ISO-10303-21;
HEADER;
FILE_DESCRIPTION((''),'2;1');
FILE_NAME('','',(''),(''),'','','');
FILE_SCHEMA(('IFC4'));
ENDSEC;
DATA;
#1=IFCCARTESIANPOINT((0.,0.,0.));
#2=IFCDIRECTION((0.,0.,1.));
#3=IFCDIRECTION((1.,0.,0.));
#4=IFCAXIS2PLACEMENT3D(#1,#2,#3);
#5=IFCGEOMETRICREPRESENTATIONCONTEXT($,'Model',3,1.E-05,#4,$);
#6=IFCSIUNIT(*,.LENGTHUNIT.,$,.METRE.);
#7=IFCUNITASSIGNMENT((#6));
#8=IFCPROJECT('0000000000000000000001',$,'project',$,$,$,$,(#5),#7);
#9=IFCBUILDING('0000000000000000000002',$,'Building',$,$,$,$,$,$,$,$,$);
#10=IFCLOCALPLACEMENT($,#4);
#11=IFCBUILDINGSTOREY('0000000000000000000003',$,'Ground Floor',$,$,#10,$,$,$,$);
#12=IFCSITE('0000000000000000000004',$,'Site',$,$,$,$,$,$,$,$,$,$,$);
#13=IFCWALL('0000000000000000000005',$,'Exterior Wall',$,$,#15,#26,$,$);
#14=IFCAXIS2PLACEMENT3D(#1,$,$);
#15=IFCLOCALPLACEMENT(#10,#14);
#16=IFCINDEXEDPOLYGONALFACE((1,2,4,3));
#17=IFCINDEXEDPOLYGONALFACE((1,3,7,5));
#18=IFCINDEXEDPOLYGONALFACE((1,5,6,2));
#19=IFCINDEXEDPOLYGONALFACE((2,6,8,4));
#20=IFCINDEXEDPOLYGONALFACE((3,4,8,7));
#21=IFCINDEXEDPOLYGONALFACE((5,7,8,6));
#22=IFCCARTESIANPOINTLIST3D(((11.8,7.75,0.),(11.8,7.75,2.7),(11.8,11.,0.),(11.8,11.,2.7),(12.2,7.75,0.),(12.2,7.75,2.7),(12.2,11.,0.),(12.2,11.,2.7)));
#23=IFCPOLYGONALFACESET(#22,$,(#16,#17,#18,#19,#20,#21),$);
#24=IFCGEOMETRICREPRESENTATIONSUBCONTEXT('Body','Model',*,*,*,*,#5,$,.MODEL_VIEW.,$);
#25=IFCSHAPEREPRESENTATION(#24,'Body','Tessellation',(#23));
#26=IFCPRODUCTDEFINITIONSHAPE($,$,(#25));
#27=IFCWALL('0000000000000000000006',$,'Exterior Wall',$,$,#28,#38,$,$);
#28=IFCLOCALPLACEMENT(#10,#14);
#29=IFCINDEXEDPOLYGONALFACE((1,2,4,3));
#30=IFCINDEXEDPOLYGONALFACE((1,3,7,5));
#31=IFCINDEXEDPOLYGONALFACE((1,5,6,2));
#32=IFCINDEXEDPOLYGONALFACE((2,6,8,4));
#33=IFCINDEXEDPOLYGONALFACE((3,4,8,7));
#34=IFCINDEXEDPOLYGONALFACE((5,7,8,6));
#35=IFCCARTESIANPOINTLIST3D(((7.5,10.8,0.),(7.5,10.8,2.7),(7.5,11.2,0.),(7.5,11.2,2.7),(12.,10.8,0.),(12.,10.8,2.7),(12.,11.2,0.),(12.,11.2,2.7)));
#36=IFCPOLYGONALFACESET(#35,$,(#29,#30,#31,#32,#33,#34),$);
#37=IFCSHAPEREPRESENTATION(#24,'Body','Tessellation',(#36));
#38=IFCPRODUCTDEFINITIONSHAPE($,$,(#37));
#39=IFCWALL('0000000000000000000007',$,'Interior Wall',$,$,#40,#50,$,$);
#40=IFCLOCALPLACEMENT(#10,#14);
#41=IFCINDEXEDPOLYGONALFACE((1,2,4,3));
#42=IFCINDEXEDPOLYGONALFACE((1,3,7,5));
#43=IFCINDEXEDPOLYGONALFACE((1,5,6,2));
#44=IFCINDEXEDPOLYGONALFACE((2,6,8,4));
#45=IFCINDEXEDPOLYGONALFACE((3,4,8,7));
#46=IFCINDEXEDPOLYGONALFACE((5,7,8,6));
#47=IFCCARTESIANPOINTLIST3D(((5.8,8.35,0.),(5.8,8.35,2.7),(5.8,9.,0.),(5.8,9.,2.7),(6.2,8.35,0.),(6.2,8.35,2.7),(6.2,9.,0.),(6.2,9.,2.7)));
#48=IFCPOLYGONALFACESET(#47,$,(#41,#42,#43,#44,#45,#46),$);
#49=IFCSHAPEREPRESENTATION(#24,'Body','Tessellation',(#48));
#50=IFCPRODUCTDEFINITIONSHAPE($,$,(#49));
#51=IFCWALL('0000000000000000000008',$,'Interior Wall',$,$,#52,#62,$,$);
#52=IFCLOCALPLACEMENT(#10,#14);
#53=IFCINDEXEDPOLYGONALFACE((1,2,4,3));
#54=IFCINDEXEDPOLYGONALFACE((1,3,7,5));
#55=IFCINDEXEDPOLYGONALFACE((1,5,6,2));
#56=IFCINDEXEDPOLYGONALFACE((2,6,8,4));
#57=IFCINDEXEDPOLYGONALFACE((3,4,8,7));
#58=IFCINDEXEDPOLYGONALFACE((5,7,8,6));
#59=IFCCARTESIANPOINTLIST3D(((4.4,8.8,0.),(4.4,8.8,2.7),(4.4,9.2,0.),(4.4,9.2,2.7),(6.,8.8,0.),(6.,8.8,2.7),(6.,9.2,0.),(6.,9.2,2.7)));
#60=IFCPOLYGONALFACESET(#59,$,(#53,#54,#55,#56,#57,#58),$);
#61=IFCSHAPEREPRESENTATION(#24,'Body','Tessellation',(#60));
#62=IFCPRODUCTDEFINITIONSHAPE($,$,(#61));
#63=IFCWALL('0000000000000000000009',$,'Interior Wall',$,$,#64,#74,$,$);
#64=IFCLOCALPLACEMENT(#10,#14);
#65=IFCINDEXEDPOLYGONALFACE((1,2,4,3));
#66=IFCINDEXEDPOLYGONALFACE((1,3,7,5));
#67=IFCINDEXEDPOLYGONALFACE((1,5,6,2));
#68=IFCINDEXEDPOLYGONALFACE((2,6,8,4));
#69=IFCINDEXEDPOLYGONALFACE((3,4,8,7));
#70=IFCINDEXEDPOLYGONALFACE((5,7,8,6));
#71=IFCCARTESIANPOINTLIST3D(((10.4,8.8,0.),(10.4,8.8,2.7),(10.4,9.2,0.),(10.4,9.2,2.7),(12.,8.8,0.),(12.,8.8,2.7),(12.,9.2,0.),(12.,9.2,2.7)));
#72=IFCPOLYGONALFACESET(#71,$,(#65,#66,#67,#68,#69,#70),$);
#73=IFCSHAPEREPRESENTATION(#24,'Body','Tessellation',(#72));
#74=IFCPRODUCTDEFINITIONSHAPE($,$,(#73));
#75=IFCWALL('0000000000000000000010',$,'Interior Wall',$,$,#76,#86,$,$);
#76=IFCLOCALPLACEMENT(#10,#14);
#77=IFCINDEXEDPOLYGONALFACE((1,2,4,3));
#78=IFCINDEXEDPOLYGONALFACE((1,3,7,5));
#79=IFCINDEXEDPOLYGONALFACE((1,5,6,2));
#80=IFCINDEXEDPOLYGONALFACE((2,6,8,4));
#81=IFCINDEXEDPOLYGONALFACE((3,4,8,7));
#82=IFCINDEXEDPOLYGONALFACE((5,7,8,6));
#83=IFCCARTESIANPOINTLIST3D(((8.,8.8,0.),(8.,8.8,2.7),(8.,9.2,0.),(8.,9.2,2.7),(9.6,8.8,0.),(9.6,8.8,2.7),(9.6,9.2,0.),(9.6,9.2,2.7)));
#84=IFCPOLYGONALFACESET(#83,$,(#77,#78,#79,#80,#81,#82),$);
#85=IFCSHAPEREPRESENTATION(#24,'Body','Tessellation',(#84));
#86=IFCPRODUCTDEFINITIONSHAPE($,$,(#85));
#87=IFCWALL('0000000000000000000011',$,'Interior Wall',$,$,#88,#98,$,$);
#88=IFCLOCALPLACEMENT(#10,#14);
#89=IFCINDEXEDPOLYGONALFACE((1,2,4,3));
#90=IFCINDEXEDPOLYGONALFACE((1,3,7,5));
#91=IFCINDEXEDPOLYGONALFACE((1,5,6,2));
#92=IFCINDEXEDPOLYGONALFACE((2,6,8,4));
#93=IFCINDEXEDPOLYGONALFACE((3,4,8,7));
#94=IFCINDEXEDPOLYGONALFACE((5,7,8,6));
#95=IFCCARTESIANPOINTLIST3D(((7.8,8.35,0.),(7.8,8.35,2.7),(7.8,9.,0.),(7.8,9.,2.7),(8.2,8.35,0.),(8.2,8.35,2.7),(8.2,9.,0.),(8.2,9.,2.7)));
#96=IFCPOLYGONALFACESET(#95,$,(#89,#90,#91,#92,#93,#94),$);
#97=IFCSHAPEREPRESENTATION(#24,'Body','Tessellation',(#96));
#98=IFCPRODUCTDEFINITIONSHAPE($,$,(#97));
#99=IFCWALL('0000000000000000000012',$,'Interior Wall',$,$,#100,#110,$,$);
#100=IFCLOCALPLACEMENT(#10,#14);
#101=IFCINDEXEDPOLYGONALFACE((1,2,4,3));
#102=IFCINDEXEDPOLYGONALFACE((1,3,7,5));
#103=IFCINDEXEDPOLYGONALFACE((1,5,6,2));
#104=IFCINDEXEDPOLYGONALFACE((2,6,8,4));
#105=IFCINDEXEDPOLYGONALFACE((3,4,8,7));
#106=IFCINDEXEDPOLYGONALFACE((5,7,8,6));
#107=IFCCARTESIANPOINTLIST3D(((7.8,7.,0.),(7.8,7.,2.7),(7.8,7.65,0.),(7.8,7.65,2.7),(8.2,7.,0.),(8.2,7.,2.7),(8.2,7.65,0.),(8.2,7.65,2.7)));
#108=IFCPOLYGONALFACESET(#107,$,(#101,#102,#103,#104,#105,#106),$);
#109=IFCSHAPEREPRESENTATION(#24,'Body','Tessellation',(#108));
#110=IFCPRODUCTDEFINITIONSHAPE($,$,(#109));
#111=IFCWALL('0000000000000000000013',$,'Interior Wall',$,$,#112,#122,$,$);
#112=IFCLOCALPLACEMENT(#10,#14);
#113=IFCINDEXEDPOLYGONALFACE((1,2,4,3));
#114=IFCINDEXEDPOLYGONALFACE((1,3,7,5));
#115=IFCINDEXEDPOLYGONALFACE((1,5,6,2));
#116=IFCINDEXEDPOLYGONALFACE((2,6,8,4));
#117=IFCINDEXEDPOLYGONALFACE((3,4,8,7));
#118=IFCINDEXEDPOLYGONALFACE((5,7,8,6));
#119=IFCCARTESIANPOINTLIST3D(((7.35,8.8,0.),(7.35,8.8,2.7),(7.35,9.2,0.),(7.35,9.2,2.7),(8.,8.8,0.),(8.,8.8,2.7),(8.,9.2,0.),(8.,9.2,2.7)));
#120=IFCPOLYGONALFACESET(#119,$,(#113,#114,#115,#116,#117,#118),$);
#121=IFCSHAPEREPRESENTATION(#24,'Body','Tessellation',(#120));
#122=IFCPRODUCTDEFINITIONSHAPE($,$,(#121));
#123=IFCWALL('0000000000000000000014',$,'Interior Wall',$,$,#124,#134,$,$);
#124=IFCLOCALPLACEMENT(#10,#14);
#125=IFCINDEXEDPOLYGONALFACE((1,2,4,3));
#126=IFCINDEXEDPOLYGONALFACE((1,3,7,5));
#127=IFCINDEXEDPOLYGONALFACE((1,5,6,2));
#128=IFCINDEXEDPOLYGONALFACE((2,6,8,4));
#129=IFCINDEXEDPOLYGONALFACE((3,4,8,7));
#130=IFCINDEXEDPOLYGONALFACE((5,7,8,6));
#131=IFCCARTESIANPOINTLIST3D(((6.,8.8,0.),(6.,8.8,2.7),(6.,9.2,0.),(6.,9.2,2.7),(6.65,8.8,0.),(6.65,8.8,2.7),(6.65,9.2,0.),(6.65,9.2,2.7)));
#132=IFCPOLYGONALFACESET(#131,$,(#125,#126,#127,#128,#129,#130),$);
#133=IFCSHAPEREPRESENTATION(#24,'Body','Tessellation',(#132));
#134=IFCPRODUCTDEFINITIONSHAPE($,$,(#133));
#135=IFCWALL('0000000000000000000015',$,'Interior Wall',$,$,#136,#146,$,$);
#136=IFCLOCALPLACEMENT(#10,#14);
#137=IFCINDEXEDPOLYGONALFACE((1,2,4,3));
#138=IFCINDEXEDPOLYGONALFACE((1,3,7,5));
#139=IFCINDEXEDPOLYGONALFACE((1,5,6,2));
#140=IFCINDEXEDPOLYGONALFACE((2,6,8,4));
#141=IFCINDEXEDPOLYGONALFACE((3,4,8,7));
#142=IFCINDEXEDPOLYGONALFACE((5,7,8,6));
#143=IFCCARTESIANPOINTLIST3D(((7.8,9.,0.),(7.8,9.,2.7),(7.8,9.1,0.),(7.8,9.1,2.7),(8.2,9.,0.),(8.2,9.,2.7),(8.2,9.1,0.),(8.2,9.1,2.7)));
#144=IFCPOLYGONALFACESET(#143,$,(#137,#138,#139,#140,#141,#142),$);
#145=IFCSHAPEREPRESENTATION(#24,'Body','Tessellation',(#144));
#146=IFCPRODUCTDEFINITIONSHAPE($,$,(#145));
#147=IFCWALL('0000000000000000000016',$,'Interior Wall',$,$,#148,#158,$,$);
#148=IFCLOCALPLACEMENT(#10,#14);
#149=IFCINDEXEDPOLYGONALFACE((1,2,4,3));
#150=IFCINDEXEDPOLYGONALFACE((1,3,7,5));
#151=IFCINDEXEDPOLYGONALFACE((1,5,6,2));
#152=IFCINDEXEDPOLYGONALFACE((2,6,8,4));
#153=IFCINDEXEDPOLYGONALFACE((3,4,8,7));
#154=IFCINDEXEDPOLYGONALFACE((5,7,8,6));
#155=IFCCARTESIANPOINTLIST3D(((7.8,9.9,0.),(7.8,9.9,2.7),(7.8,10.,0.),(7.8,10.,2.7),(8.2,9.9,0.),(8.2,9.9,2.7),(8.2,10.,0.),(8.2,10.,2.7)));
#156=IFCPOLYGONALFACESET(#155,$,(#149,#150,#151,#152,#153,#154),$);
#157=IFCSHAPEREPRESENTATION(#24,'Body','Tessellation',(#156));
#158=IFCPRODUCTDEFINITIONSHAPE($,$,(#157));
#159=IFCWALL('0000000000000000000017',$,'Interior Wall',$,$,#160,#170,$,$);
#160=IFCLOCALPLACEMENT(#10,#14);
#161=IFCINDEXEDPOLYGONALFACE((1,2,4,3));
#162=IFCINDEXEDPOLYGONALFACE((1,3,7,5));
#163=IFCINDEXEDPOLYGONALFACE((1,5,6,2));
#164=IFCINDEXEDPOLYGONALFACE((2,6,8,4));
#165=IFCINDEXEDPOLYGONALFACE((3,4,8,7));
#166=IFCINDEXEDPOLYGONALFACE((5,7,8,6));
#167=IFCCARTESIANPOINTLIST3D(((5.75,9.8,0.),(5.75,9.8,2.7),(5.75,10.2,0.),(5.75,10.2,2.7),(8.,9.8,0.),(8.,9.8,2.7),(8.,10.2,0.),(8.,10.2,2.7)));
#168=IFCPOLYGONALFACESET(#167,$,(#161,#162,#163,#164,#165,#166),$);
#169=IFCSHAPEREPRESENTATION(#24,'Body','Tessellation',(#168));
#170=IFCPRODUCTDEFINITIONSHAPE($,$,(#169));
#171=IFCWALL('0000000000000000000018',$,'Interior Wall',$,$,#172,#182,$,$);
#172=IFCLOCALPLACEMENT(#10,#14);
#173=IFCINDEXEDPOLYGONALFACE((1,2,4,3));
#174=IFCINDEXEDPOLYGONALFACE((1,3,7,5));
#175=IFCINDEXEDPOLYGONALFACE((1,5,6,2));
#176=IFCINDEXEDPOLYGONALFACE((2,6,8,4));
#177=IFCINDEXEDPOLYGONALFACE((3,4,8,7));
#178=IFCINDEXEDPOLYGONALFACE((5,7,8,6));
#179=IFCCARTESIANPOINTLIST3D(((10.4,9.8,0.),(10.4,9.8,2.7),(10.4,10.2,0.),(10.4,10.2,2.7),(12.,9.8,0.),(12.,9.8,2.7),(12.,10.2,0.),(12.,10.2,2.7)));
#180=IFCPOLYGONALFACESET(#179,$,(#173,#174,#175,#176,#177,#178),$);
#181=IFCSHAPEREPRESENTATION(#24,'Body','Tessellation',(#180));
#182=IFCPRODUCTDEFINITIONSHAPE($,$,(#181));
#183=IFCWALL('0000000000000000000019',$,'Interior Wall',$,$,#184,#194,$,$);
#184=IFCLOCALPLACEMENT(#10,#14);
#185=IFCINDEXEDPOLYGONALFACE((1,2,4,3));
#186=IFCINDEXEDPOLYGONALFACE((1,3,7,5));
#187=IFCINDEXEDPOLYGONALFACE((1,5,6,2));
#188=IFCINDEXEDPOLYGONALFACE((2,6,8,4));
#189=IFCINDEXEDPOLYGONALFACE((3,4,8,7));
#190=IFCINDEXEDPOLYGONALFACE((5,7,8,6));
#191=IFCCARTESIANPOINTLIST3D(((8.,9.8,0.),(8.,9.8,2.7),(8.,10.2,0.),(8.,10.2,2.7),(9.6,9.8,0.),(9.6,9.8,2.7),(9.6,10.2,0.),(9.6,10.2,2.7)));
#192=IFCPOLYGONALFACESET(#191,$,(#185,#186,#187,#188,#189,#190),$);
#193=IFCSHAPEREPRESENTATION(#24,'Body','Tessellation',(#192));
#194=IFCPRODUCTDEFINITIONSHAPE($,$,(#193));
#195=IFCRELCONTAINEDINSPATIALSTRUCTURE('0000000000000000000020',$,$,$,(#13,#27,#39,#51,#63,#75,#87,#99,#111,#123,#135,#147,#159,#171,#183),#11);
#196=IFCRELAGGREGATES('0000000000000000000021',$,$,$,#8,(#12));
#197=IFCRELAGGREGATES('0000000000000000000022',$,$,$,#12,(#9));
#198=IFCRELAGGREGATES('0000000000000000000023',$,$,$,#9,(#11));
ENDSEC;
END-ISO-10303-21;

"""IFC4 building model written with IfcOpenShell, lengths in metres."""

from ifc_helpers import new_model, si_unit, frame, origin_with_axes, place, context, subcontext, project, spatial, indexed_curve, outline, extrude, element, save


model = new_model("IFC4")

# Units and contexts
model_context = context("Model", 3, precision=1e-05, world=origin_with_axes())
body_context = subcontext(model_context, "Body", "Model", "MODEL_VIEW")
ifc_project = project(units=[si_unit("LENGTHUNIT", "METRE")], contexts=[model_context])

# Site, building, storey
site = spatial("IfcSite", under=ifc_project, Name="Site")
building = spatial("IfcBuilding", under=site, Name="Building")
storey_placement = place(None, origin_with_axes())
storey = spatial("IfcBuildingStorey", under=building, at=storey_placement, Name="Ground Floor")

# Walls
wall_1_placement = place(storey_placement, frame((12.0, 7.75, 0.0), z_axis=(0.0, 0.0, 1.0), x_axis=(0.0, 1.0, 0.0)))
element("IfcWall", 1, at=wall_1_placement, inside=storey, Name="Exterior Wall", context=body_context, shape_type="SweptSolid", body=[
    extrude(outline(indexed_curve([(0.0, 0.0), (0.0, 0.4), (3.25, 0.4), (3.25, 0.0), (0.0, 0.0)], self_intersect=False)), frame((0.0, -0.2, 0.0), z_axis=(0.0, 0.0, 1.0), x_axis=(1.0, 0.0, 0.0)), (0.0, 0.0, 1.0), 2.7),
])
wall_2_placement = place(storey_placement, frame((12.0, 11.0, 0.0), z_axis=(0.0, 0.0, 1.0), x_axis=(-1.0, 0.0, 0.0)))
element("IfcWall", 2, at=wall_2_placement, inside=storey, Name="Exterior Wall", context=body_context, shape_type="SweptSolid", body=[
    extrude(outline(indexed_curve([(0.0, 0.0), (0.0, 0.4), (4.5, 0.4), (4.5, 0.0), (0.0, 0.0)], self_intersect=False)), frame((0.0, -0.2, 0.0), z_axis=(0.0, 0.0, 1.0), x_axis=(1.0, 0.0, 0.0)), (0.0, 0.0, 1.0), 2.7),
])
wall_3_placement = place(storey_placement, frame((6.0, 8.35, 0.0), z_axis=(0.0, 0.0, 1.0), x_axis=(0.0, 1.0, 0.0)))
element("IfcWall", 3, at=wall_3_placement, inside=storey, Name="Interior Wall", context=body_context, shape_type="SweptSolid", body=[
    extrude(outline(indexed_curve([(0.0, 0.0), (0.0, 0.4), (0.65, 0.4), (0.65, 0.0), (0.0, 0.0)], self_intersect=False)), frame((0.0, -0.2, 0.0), z_axis=(0.0, 0.0, 1.0), x_axis=(1.0, 0.0, 0.0)), (0.0, 0.0, 1.0), 2.7),
])
for number, where, z_axis, x_axis, name in (
    (4, (6.0, 9.0, 0.0), (0.0, 0.0, 1.0), (-1.0, 0.0, 0.0), "Interior Wall"),
    (5, (12.0, 9.0, 0.0), (0.0, 0.0, 1.0), (-1.0, 0.0, 0.0), "Interior Wall"),
    (6, (9.6, 9.0, 0.0), (0.0, 0.0, 1.0), (-1.0, 0.0, 0.0), "Interior Wall"),
):
    element("IfcWall", number, at=place(storey_placement, frame(where, z_axis=z_axis, x_axis=x_axis)), inside=storey, Name=name, context=body_context, shape_type="SweptSolid", body=[
        extrude(outline(indexed_curve([(0.0, 0.0), (0.0, 0.4), (1.6, 0.4), (1.6, 0.0), (0.0, 0.0)], self_intersect=False)), frame((0.0, -0.2, 0.0), z_axis=(0.0, 0.0, 1.0), x_axis=(1.0, 0.0, 0.0)), (0.0, 0.0, 1.0), 2.7),
    ])
for number, where, z_axis, x_axis, name in (
    (7, (8.0, 9.0, 0.0), (0.0, 0.0, 1.0), (0.0, -1.0, 0.0), "Interior Wall"),
    (8, (8.0, 7.65, 0.0), (0.0, 0.0, 1.0), (0.0, -1.0, 0.0), "Interior Wall"),
    (9, (8.0, 9.0, 0.0), (0.0, 0.0, 1.0), (-1.0, 0.0, 0.0), "Interior Wall"),
    (10, (6.65, 9.0, 0.0), (0.0, 0.0, 1.0), (-1.0, 0.0, 0.0), "Interior Wall"),
):
    element("IfcWall", number, at=place(storey_placement, frame(where, z_axis=z_axis, x_axis=x_axis)), inside=storey, Name=name, context=body_context, shape_type="SweptSolid", body=[
        extrude(outline(indexed_curve([(0.0, 0.0), (0.0, 0.4), (0.65, 0.4), (0.65, 0.0), (0.0, 0.0)], self_intersect=False)), frame((0.0, -0.2, 0.0), z_axis=(0.0, 0.0, 1.0), x_axis=(1.0, 0.0, 0.0)), (0.0, 0.0, 1.0), 2.7),
    ])
for number, where, z_axis, x_axis, name in (
    (11, (8.0, 9.0, 0.0), (0.0, 0.0, 1.0), (0.0, 1.0, 0.0), "Interior Wall"),
    (12, (8.0, 9.9, 0.0), (0.0, 0.0, 1.0), (0.0, 1.0, 0.0), "Interior Wall"),
):
    element("IfcWall", number, at=place(storey_placement, frame(where, z_axis=z_axis, x_axis=x_axis)), inside=storey, Name=name, context=body_context, shape_type="SweptSolid", body=[
        extrude(outline(indexed_curve([(0.0, 0.0), (0.0, 0.4), (0.1, 0.4), (0.1, 0.0), (0.0, 0.0)], self_intersect=False)), frame((0.0, -0.2, 0.0), z_axis=(0.0, 0.0, 1.0), x_axis=(1.0, 0.0, 0.0)), (0.0, 0.0, 1.0), 2.7),
    ])
wall_4_placement = place(storey_placement, frame((8.0, 10.0, 0.0), z_axis=(0.0, 0.0, 1.0), x_axis=(-1.0, 0.0, 0.0)))
element("IfcWall", 13, at=wall_4_placement, inside=storey, Name="Interior Wall", context=body_context, shape_type="SweptSolid", body=[
    extrude(outline(indexed_curve([(0.0, 0.0), (0.0, 0.4), (2.25, 0.4), (2.25, 0.0), (0.0, 0.0)], self_intersect=False)), frame((0.0, -0.2, 0.0), z_axis=(0.0, 0.0, 1.0), x_axis=(1.0, 0.0, 0.0)), (0.0, 0.0, 1.0), 2.7),
])
for number, where, z_axis, x_axis, name in (
    (14, (12.0, 10.0, 0.0), (0.0, 0.0, 1.0), (-1.0, 0.0, 0.0), "Interior Wall"),
    (15, (9.6, 10.0, 0.0), (0.0, 0.0, 1.0), (-1.0, 0.0, 0.0), "Interior Wall"),
):
    element("IfcWall", number, at=place(storey_placement, frame(where, z_axis=z_axis, x_axis=x_axis)), inside=storey, Name=name, context=body_context, shape_type="SweptSolid", body=[
        extrude(outline(indexed_curve([(0.0, 0.0), (0.0, 0.4), (1.6, 0.4), (1.6, 0.0), (0.0, 0.0)], self_intersect=False)), frame((0.0, -0.2, 0.0), z_axis=(0.0, 0.0, 1.0), x_axis=(1.0, 0.0, 0.0)), (0.0, 0.0, 1.0), 2.7),
    ])

save(model, "model.ifc")
